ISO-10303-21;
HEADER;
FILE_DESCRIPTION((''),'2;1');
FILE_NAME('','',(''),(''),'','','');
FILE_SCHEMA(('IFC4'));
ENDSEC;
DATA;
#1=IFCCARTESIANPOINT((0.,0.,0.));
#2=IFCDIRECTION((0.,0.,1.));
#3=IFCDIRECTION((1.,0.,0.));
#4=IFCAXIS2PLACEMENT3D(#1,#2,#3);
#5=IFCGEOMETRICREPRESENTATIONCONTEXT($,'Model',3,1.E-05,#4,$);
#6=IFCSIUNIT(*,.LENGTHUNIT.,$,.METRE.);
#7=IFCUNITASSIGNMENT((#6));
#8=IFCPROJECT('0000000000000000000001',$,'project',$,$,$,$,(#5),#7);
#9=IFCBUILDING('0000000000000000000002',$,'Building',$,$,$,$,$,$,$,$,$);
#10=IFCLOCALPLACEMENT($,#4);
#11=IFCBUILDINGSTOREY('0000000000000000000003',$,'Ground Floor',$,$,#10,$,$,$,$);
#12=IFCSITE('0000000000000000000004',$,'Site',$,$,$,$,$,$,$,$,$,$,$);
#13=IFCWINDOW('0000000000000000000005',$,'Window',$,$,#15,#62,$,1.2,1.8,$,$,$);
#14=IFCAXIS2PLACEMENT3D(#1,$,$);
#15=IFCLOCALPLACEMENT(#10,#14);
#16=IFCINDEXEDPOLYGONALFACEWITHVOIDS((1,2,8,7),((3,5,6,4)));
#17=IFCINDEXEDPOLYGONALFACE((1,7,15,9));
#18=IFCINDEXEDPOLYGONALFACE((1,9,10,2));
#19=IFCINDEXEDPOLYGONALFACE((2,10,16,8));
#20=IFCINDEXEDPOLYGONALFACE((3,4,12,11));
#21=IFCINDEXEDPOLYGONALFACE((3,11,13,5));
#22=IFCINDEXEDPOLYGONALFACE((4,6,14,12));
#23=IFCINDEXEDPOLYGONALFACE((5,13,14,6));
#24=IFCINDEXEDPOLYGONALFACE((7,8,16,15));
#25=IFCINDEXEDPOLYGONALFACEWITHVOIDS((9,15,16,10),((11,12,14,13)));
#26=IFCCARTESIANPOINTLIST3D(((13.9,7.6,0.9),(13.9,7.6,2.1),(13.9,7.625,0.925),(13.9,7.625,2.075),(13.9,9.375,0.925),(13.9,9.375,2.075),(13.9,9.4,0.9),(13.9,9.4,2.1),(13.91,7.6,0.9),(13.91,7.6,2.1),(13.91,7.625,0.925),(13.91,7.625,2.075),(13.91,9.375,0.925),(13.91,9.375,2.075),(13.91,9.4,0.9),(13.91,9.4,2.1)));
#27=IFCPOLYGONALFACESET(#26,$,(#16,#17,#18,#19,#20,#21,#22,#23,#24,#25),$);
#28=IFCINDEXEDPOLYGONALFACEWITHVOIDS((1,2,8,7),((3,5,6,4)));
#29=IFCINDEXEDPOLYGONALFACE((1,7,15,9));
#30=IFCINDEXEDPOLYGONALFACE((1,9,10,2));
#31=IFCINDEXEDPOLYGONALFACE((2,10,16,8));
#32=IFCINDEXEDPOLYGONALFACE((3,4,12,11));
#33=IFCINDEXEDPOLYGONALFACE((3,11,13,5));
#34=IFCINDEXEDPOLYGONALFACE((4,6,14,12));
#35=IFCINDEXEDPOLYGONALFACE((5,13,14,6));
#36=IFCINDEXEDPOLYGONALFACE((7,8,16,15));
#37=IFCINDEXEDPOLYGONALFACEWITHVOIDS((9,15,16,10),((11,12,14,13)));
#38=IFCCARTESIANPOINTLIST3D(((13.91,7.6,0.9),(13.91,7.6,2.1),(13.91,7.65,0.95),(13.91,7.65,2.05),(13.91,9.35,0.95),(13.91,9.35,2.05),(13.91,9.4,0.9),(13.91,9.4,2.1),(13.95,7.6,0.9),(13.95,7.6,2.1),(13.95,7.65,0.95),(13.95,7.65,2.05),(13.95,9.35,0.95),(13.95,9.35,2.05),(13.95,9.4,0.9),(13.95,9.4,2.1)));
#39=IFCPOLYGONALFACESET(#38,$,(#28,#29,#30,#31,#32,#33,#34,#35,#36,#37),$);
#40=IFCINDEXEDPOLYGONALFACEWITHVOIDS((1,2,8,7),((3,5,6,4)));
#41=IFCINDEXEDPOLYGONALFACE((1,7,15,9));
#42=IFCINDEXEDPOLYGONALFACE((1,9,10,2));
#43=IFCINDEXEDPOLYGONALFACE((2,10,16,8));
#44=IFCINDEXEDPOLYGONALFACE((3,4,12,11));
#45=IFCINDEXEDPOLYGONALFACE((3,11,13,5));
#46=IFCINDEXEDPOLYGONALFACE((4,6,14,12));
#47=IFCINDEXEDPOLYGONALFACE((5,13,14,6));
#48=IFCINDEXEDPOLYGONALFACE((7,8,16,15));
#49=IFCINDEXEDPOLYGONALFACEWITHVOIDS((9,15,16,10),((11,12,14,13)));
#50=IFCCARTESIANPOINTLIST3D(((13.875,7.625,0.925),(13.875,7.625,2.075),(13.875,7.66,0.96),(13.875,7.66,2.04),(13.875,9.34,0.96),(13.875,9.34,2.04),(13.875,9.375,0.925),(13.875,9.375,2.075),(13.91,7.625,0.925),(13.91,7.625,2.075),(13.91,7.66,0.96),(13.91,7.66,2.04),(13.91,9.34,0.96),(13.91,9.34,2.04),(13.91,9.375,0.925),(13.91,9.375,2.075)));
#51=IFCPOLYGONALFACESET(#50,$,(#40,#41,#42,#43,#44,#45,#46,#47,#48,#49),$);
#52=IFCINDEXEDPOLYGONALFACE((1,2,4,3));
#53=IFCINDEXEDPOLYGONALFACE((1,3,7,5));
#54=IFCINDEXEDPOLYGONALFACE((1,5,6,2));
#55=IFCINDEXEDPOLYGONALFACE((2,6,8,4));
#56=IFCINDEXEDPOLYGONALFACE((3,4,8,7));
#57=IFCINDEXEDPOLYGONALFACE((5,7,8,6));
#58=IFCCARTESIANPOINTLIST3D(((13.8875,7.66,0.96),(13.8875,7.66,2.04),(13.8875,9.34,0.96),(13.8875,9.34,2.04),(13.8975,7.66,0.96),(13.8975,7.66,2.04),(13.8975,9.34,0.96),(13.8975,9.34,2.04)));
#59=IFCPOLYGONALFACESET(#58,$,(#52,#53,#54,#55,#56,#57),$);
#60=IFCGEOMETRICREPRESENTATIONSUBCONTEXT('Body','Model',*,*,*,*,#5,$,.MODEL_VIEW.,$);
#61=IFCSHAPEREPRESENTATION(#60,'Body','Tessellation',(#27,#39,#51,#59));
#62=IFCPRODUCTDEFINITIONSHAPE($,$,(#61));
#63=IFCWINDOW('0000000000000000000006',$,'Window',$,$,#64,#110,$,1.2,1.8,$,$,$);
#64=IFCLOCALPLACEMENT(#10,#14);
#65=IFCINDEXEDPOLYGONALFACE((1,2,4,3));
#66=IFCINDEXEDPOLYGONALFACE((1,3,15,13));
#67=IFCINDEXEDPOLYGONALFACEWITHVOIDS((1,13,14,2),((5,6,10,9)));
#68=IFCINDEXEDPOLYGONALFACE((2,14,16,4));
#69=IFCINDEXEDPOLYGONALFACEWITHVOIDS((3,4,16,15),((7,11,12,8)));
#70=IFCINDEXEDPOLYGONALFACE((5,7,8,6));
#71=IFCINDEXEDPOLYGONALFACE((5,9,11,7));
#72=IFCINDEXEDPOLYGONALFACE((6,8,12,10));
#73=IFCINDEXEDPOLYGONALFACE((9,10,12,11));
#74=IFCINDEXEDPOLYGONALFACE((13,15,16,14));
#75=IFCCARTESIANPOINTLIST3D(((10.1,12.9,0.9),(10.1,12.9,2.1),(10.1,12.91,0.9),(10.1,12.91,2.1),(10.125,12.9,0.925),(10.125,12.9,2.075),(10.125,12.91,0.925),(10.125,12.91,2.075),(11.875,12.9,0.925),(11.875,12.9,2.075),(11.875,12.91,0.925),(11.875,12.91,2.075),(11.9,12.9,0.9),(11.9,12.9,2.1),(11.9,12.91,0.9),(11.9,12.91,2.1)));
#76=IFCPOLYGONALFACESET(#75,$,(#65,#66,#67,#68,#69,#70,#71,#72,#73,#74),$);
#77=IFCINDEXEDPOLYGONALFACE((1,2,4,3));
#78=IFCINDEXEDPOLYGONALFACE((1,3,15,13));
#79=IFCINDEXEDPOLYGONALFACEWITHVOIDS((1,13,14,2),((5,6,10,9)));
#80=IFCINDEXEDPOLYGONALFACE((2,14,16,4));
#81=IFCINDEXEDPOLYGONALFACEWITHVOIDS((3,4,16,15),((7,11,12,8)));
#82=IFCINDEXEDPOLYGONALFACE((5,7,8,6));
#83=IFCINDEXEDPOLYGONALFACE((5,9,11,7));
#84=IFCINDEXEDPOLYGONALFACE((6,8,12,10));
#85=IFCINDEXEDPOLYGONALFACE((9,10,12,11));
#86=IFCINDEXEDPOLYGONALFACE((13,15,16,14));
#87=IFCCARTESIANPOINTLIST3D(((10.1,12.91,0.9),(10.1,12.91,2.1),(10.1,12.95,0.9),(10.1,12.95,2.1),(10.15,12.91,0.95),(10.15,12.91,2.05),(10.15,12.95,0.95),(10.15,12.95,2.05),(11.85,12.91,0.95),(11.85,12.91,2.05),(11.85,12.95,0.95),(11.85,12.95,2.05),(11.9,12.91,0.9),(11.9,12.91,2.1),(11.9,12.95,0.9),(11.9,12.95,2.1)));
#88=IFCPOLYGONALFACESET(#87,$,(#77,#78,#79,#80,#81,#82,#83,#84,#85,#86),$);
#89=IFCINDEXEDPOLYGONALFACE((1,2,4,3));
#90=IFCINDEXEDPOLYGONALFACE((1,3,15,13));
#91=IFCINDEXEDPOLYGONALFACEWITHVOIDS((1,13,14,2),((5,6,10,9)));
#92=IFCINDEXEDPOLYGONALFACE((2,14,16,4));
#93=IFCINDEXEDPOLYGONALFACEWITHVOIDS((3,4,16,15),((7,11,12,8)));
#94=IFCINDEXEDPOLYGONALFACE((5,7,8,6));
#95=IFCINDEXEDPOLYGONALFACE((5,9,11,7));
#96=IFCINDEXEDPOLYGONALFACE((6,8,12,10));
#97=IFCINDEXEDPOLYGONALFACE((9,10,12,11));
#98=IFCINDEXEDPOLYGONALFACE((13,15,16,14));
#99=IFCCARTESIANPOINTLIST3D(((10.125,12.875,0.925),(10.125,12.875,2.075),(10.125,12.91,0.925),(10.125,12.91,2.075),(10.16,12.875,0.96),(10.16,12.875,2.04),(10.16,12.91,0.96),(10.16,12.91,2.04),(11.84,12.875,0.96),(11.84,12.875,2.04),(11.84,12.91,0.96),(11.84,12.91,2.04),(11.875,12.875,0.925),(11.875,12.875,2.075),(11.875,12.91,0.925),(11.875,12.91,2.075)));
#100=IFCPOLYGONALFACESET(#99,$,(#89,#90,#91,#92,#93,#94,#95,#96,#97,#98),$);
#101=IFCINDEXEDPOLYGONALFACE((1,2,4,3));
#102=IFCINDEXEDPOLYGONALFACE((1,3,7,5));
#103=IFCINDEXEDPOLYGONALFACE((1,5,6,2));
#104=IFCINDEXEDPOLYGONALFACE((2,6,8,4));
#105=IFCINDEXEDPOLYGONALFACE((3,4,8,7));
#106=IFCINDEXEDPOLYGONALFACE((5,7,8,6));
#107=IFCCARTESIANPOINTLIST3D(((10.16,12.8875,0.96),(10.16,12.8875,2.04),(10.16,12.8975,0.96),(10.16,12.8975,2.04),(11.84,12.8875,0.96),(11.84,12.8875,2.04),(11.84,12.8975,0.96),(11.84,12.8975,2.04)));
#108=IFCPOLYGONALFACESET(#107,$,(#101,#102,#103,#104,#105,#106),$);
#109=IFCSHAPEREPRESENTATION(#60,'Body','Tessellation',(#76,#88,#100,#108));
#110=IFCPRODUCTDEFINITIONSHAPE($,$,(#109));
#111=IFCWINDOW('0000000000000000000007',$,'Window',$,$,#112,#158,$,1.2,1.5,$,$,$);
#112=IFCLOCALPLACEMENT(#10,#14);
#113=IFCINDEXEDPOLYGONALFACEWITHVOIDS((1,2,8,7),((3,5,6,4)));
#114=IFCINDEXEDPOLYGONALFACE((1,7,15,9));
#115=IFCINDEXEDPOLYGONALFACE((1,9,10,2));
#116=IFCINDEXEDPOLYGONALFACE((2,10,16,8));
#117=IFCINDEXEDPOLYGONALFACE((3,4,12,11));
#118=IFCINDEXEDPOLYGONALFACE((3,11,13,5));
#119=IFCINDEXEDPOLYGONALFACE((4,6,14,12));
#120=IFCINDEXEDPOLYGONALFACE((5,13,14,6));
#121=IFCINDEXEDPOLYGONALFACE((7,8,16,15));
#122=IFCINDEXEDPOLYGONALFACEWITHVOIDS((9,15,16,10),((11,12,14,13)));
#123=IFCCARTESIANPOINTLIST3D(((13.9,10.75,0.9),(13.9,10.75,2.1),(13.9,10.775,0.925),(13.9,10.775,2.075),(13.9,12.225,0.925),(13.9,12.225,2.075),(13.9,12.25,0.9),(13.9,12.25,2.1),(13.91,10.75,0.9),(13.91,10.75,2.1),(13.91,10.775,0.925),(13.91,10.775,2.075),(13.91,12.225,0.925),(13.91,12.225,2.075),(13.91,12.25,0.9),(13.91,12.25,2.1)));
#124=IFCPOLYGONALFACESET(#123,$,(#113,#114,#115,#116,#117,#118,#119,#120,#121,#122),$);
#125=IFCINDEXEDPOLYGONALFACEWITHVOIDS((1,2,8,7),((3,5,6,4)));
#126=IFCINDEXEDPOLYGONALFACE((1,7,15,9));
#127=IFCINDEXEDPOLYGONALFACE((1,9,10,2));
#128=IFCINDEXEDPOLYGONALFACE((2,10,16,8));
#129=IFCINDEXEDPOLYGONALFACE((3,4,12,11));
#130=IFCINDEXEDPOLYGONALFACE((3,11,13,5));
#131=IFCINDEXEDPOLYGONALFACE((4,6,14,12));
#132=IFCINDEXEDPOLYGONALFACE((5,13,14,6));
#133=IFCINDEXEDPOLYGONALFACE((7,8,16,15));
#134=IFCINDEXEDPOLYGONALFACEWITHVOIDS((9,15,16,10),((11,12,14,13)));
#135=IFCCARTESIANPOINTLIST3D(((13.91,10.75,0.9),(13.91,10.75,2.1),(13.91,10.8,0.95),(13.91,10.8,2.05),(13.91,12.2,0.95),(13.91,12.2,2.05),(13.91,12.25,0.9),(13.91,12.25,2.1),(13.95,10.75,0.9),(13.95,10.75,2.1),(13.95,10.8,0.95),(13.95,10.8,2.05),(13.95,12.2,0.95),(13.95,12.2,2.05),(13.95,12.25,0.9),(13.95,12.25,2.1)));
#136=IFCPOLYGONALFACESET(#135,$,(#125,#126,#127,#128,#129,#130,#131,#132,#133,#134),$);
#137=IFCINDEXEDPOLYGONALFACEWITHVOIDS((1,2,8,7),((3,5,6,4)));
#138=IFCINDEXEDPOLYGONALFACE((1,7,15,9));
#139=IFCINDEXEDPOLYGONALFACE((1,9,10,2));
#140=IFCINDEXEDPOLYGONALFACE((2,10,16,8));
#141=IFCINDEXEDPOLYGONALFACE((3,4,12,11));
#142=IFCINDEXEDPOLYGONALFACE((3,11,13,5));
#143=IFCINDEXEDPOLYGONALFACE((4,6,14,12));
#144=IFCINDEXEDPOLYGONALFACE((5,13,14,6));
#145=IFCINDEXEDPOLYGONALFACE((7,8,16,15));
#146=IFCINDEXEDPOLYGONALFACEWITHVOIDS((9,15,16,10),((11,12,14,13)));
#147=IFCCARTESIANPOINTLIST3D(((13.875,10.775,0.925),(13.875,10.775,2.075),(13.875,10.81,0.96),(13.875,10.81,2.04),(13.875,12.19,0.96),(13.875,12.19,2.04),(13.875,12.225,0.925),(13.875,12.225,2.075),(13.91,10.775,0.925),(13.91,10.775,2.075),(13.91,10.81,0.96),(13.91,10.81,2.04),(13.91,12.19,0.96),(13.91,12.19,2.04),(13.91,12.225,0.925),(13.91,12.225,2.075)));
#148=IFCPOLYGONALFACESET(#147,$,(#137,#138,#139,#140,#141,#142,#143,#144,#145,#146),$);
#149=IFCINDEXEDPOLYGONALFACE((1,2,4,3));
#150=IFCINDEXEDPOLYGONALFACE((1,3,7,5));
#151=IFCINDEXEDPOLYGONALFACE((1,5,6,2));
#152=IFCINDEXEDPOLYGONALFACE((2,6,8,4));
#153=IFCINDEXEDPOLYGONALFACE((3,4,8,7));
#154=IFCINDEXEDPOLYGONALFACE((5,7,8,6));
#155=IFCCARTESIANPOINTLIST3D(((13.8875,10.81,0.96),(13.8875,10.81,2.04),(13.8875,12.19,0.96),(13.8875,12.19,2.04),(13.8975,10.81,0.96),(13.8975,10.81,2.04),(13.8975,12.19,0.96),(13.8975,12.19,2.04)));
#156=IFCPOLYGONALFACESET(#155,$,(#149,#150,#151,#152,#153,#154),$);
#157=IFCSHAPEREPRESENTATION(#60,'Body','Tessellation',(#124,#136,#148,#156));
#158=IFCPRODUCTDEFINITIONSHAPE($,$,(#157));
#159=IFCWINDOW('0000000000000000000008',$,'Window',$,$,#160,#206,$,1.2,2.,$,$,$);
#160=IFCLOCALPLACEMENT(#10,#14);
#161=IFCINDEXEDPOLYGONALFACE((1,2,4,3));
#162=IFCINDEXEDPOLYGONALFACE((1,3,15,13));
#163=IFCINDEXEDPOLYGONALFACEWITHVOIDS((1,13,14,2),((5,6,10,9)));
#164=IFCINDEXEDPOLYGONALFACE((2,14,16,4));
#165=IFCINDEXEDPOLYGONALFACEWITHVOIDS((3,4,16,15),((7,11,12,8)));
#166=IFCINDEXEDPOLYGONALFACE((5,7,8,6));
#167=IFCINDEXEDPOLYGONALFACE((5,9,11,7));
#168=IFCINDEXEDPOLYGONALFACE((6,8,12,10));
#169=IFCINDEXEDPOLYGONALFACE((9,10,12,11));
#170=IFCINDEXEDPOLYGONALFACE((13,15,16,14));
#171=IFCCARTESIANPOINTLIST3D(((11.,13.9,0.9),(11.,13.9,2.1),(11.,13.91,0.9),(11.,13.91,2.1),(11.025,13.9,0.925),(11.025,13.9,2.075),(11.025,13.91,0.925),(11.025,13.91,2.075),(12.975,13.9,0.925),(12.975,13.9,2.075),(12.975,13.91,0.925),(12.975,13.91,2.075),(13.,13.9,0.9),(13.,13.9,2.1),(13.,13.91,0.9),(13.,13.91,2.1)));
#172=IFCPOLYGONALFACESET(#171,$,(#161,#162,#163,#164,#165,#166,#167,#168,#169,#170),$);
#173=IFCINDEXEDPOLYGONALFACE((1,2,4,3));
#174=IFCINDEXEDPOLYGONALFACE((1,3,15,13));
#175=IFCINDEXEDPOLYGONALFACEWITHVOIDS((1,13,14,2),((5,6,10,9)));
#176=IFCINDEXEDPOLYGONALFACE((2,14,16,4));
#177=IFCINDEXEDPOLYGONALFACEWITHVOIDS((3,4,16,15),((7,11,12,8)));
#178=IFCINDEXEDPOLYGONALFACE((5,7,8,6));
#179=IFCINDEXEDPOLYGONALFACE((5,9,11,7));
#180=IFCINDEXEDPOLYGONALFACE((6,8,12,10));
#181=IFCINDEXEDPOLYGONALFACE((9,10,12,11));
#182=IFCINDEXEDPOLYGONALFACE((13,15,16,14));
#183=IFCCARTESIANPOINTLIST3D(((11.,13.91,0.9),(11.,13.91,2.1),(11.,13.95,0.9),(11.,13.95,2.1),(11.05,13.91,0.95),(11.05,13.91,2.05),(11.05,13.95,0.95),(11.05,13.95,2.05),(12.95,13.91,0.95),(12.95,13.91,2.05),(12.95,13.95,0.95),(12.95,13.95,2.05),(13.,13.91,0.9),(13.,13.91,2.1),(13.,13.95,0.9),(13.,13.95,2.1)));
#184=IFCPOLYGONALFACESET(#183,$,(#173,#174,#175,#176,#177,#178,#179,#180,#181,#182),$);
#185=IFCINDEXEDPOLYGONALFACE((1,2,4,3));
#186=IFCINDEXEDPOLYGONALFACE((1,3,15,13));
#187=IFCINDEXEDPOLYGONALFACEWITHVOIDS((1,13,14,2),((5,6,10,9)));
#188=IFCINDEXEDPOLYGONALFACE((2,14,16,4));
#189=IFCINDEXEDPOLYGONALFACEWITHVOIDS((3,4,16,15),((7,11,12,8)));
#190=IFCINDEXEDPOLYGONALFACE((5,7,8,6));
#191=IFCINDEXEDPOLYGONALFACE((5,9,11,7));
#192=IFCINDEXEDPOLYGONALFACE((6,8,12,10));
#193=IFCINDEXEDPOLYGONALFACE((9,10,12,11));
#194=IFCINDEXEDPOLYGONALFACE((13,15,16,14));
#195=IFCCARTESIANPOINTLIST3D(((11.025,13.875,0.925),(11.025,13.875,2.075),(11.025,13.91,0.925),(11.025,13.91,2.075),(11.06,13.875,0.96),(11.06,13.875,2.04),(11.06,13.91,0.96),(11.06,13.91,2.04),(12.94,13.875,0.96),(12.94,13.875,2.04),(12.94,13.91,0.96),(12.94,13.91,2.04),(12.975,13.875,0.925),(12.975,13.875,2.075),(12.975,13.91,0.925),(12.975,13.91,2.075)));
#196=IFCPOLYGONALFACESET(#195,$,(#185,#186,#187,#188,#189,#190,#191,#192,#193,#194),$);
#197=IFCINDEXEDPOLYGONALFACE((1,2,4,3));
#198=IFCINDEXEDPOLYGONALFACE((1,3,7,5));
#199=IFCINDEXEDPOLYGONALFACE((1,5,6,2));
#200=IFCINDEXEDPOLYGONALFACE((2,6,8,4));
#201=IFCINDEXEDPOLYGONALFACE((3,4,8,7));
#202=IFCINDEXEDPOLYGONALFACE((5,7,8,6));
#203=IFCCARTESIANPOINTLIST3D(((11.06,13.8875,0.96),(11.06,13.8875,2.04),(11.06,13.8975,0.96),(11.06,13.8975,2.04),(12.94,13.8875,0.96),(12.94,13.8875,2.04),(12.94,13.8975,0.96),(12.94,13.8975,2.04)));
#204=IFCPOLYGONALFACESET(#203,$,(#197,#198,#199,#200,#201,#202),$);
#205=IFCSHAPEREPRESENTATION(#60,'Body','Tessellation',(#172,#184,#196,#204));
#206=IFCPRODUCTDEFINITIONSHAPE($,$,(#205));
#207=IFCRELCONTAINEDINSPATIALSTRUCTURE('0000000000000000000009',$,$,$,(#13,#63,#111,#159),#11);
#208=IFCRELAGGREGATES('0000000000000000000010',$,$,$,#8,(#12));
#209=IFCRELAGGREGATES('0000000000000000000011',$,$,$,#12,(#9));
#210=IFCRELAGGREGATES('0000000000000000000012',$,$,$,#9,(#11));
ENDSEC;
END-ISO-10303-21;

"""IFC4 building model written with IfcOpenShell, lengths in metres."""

from ifc_helpers import new_model, si_unit, frame, origin_with_axes, place, context, subcontext, project, spatial, line, indexed_curve, outline, extrude, element, save


model = new_model("IFC4")

# Units and contexts
model_context = context("Model", 3, precision=1e-05, world=origin_with_axes())
body_context = subcontext(model_context, "Body", "Model", "MODEL_VIEW")
ifc_project = project(units=[si_unit("LENGTHUNIT", "METRE")], contexts=[model_context])

# Site, building, storey
site = spatial("IfcSite", under=ifc_project, Name="Site")
building = spatial("IfcBuilding", under=site, Name="Building")
storey_placement = place(None, origin_with_axes())
storey = spatial("IfcBuildingStorey", under=building, at=storey_placement, Name="Ground Floor")

# Windows
for number, where, z_axis, x_axis, name in (
    (1, (14.0, 7.6, 0.9), (0.0, 0.0, 1.0), (0.0, 1.0, 0.0), "Window"),
    (2, (11.9, 13.0, 0.9), (0.0, 0.0, 1.0), (-1.0, 0.0, 0.0), "Window"),
):
    element("IfcWindow", number, at=place(storey_placement, frame(where, z_axis=z_axis, x_axis=x_axis)), inside=storey, Name=name, OverallHeight=1.2, OverallWidth=1.8, context=body_context, shape_type="SweptSolid", body=[
        extrude(outline(indexed_curve([(0.0, 0.0), (1.8, 0.0), (1.8, 1.2), (0.0, 1.2)], segments=[line(1, 2, 3, 4, 1)]), holes=[indexed_curve([(0.025, 0.025), (1.775, 0.025), (1.775, 1.175), (0.025, 1.175)], segments=[line(1, 2, 3, 4, 1)])]), frame((0.0, 0.09, 0.0), z_axis=(0.0, -1.0, 0.0), x_axis=(1.0, 0.0, 0.0)), (0.0, 0.0, -1.0), 0.01),
        extrude(outline(indexed_curve([(0.0, 0.0), (1.8, 0.0), (1.8, 1.2), (0.0, 1.2)], segments=[line(1, 2, 3, 4, 1)]), holes=[indexed_curve([(0.05, 0.05), (1.75, 0.05), (1.75, 1.15), (0.05, 1.15)], segments=[line(1, 2, 3, 4, 1)])]), frame((0.0, 0.05, 0.0), z_axis=(0.0, -1.0, 0.0), x_axis=(1.0, 0.0, 0.0)), (0.0, 0.0, -1.0), 0.04),
        extrude(outline(indexed_curve([(0.0, 0.0), (1.75, 0.0), (1.75, 1.15), (0.0, 1.15)], segments=[line(1, 2, 3, 4, 1)]), holes=[indexed_curve([(0.035, 0.035), (1.715, 0.035), (1.715, 1.115), (0.035, 1.115)], segments=[line(1, 2, 3, 4, 1)])]), frame((0.025, 0.09, 0.025), z_axis=(0.0, -1.0, 0.0), x_axis=(1.0, 0.0, 0.0)), (0.0, 0.0, -1.0), 0.035),
        extrude(outline(indexed_curve([(0.035, 0.035), (1.715, 0.035), (1.715, 1.115), (0.035, 1.115)], segments=[line(1, 2, 3, 4, 1)])), frame((0.025, 0.1025, 0.025), z_axis=(0.0, -1.0, 0.0), x_axis=(1.0, 0.0, 0.0)), (0.0, 0.0, -1.0), 0.01),
    ])
window_1_placement = place(storey_placement, frame((14.0, 10.75, 0.9), z_axis=(0.0, 0.0, 1.0), x_axis=(0.0, 1.0, 0.0)))
element("IfcWindow", 3, at=window_1_placement, inside=storey, Name="Window", OverallHeight=1.2, OverallWidth=1.5, context=body_context, shape_type="SweptSolid", body=[
    extrude(outline(indexed_curve([(0.0, 0.0), (1.5, 0.0), (1.5, 1.2), (0.0, 1.2)], segments=[line(1, 2, 3, 4, 1)]), holes=[indexed_curve([(0.025, 0.025), (1.475, 0.025), (1.475, 1.175), (0.025, 1.175)], segments=[line(1, 2, 3, 4, 1)])]), frame((0.0, 0.09, 0.0), z_axis=(0.0, -1.0, 0.0), x_axis=(1.0, 0.0, 0.0)), (0.0, 0.0, -1.0), 0.01),
    extrude(outline(indexed_curve([(0.0, 0.0), (1.5, 0.0), (1.5, 1.2), (0.0, 1.2)], segments=[line(1, 2, 3, 4, 1)]), holes=[indexed_curve([(0.05, 0.05), (1.45, 0.05), (1.45, 1.15), (0.05, 1.15)], segments=[line(1, 2, 3, 4, 1)])]), frame((0.0, 0.05, 0.0), z_axis=(0.0, -1.0, 0.0), x_axis=(1.0, 0.0, 0.0)), (0.0, 0.0, -1.0), 0.04),
    extrude(outline(indexed_curve([(0.0, 0.0), (1.45, 0.0), (1.45, 1.15), (0.0, 1.15)], segments=[line(1, 2, 3, 4, 1)]), holes=[indexed_curve([(0.035, 0.035), (1.415, 0.035), (1.415, 1.115), (0.035, 1.115)], segments=[line(1, 2, 3, 4, 1)])]), frame((0.025, 0.09, 0.025), z_axis=(0.0, -1.0, 0.0), x_axis=(1.0, 0.0, 0.0)), (0.0, 0.0, -1.0), 0.035),
    extrude(outline(indexed_curve([(0.035, 0.035), (1.415, 0.035), (1.415, 1.115), (0.035, 1.115)], segments=[line(1, 2, 3, 4, 1)])), frame((0.025, 0.1025, 0.025), z_axis=(0.0, -1.0, 0.0), x_axis=(1.0, 0.0, 0.0)), (0.0, 0.0, -1.0), 0.01),
])
window_2_placement = place(storey_placement, frame((13.0, 14.0, 0.9), z_axis=(0.0, 0.0, 1.0), x_axis=(-1.0, 0.0, 0.0)))
element("IfcWindow", 4, at=window_2_placement, inside=storey, Name="Window", OverallHeight=1.2, OverallWidth=2.0, context=body_context, shape_type="SweptSolid", body=[
    extrude(outline(indexed_curve([(0.0, 0.0), (2.0, 0.0), (2.0, 1.2), (0.0, 1.2)], segments=[line(1, 2, 3, 4, 1)]), holes=[indexed_curve([(0.025, 0.025), (1.975, 0.025), (1.975, 1.175), (0.025, 1.175)], segments=[line(1, 2, 3, 4, 1)])]), frame((0.0, 0.09, 0.0), z_axis=(0.0, -1.0, 0.0), x_axis=(1.0, 0.0, 0.0)), (0.0, 0.0, -1.0), 0.01),
    extrude(outline(indexed_curve([(0.0, 0.0), (2.0, 0.0), (2.0, 1.2), (0.0, 1.2)], segments=[line(1, 2, 3, 4, 1)]), holes=[indexed_curve([(0.05, 0.05), (1.95, 0.05), (1.95, 1.15), (0.05, 1.15)], segments=[line(1, 2, 3, 4, 1)])]), frame((0.0, 0.05, 0.0), z_axis=(0.0, -1.0, 0.0), x_axis=(1.0, 0.0, 0.0)), (0.0, 0.0, -1.0), 0.04),
    extrude(outline(indexed_curve([(0.0, 0.0), (1.95, 0.0), (1.95, 1.15), (0.0, 1.15)], segments=[line(1, 2, 3, 4, 1)]), holes=[indexed_curve([(0.035, 0.035), (1.915, 0.035), (1.915, 1.115), (0.035, 1.115)], segments=[line(1, 2, 3, 4, 1)])]), frame((0.025, 0.09, 0.025), z_axis=(0.0, -1.0, 0.0), x_axis=(1.0, 0.0, 0.0)), (0.0, 0.0, -1.0), 0.035),
    extrude(outline(indexed_curve([(0.035, 0.035), (1.915, 0.035), (1.915, 1.115), (0.035, 1.115)], segments=[line(1, 2, 3, 4, 1)])), frame((0.025, 0.1025, 0.025), z_axis=(0.0, -1.0, 0.0), x_axis=(1.0, 0.0, 0.0)), (0.0, 0.0, -1.0), 0.01),
])

save(model, "model.ifc")
